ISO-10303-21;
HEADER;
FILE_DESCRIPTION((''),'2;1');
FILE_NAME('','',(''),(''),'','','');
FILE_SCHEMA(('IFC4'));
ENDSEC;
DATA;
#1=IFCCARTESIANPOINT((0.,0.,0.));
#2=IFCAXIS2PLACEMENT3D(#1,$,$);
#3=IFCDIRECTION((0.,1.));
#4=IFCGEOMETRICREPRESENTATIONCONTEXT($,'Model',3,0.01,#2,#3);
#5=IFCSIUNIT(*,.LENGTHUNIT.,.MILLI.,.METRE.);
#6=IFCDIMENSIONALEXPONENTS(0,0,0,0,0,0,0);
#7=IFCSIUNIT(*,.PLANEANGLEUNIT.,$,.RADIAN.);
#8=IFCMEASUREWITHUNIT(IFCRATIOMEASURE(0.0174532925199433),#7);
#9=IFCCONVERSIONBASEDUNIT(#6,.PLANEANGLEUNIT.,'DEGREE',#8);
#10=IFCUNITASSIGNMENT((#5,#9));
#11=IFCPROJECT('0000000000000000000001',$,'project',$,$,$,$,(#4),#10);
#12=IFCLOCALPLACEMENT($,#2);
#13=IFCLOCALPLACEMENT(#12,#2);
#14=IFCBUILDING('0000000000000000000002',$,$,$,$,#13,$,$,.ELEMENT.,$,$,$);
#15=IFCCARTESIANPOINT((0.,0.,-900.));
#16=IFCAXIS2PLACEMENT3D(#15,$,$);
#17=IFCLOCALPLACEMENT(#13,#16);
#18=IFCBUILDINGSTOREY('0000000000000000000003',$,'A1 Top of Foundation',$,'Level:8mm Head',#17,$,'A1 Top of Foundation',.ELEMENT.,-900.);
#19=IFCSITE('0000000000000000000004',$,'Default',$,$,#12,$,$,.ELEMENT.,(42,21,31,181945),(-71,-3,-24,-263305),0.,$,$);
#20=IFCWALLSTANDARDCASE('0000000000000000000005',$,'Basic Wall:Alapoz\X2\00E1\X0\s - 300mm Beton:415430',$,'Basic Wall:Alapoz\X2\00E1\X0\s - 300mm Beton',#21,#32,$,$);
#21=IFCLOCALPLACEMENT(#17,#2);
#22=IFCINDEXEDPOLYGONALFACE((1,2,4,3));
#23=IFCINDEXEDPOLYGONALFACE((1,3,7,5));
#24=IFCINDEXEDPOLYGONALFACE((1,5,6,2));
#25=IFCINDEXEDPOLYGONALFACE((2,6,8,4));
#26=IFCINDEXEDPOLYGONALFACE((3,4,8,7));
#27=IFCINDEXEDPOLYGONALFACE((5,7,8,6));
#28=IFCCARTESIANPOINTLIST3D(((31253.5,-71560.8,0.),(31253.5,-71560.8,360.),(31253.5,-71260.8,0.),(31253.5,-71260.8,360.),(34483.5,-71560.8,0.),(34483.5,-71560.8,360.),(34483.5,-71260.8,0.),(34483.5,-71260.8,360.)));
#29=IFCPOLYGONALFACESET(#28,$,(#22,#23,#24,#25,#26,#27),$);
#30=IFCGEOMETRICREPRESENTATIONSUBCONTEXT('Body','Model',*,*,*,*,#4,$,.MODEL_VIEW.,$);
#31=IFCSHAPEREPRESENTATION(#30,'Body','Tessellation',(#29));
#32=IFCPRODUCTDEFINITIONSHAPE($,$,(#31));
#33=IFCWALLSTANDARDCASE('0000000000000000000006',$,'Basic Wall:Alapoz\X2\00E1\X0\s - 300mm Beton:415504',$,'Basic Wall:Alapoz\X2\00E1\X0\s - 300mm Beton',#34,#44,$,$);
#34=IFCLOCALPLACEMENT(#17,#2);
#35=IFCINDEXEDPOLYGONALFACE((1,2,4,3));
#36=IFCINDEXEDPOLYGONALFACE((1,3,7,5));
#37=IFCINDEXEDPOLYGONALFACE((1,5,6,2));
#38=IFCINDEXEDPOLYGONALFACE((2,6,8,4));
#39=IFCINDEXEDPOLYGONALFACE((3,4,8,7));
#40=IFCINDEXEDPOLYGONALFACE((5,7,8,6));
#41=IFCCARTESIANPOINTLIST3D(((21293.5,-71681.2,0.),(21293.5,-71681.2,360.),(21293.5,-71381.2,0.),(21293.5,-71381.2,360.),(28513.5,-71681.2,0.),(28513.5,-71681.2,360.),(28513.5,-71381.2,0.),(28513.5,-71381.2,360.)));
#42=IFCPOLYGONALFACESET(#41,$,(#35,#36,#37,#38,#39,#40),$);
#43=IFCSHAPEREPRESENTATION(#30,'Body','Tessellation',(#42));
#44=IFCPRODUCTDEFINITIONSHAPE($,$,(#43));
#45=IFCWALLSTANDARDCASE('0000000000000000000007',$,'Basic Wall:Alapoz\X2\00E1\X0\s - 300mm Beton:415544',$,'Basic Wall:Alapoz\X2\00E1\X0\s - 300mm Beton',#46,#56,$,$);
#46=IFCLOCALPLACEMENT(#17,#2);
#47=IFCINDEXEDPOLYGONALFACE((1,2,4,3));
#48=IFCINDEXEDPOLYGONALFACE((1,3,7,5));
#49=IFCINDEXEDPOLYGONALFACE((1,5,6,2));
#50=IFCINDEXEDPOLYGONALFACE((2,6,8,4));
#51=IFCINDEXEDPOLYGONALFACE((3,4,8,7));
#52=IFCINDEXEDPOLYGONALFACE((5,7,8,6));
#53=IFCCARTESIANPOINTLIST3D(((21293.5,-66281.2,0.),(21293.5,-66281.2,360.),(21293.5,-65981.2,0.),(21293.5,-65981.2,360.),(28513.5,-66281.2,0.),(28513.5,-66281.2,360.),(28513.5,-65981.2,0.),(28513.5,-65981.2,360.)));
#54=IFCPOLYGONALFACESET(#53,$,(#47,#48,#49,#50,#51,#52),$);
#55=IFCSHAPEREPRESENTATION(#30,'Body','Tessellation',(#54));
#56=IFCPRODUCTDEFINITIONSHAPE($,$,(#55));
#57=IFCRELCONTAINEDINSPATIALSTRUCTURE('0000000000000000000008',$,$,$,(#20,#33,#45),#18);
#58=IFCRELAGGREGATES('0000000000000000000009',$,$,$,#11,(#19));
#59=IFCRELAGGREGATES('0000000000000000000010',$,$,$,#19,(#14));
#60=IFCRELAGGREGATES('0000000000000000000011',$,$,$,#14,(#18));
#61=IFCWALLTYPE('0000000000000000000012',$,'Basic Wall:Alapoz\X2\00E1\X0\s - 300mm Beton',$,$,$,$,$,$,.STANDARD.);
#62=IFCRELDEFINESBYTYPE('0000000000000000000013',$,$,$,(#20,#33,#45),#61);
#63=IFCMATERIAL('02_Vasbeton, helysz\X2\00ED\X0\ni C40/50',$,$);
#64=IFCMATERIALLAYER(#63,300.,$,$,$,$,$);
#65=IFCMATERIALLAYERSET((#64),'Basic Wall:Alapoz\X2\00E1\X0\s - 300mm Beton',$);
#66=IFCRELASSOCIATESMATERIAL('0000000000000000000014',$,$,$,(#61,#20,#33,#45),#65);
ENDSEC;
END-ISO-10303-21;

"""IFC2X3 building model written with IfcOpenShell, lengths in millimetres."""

from ifc_helpers import new_model, entity, si_unit, converted_unit, direction, frame, frame_2d, origin, place, context, subcontext, project, spatial, polyline, rectangle, extrude, clip, bounded_halfspace, material, layer, layer_set, layer_usage, type_object, element, save


model = new_model("IFC2X3")

# Units and contexts
model_context = context("Model", 3, precision=0.01, world=origin(), true_north=direction((0.0, 1.0)))
body_context = subcontext(model_context, "Body", "Model", "MODEL_VIEW")
ifc_project = project(units=[si_unit("LENGTHUNIT", "METRE", prefix="MILLI"), converted_unit("PLANEANGLEUNIT", "DEGREE", entity("IfcRatioMeasure", 0.0174532925199433), si_unit("PLANEANGLEUNIT", "RADIAN"), dimensions=[0, 0, 0, 0, 0, 0, 0])], contexts=[model_context])

# Site, building, storey
site_placement = place(None, origin())
site = spatial("IfcSite", under=ifc_project, at=site_placement, Name="Default", CompositionType="ELEMENT", RefLatitude=(42, 21, 31, 181945), RefLongitude=(-71, -3, -24, -263305), RefElevation=0.0)
building_placement = place(site_placement, origin())
building = spatial("IfcBuilding", under=site, at=building_placement, CompositionType="ELEMENT")
storey_placement = place(building_placement, frame((0.0, 0.0, -900.0)))
storey = spatial("IfcBuildingStorey", under=building, at=storey_placement, Name="A1 Top of Foundation", ObjectType="Level:8mm Head", LongName="A1 Top of Foundation", CompositionType="ELEMENT", Elevation=-900.0)

# Walls
ifc_material = material(Name="02_Vasbeton, helyszíni C40/50")
ifc_layer = layer(ifc_material, 300.0)
ifc_layer_set = layer_set([ifc_layer], Name="Basic Wall:Alapozás - 300mm Beton")
wall_type = type_object("IfcWallType", Name="Basic Wall:Alapozás - 300mm Beton", PredefinedType="STANDARD", material=ifc_layer_set)
ifc_layer_usage_1 = layer_usage(ifc_layer_set, "AXIS2", "POSITIVE", -150.0)
wall_1_placement = place(storey_placement, frame((31253.5, -71410.8, 0.0)))
element("IfcWallStandardCase", 1, at=wall_1_placement, inside=storey, type_object=wall_type, material=ifc_layer_usage_1, Name="Basic Wall:Alapozás - 300mm Beton:415430", ObjectType="Basic Wall:Alapozás - 300mm Beton", context=body_context, shape_type="Clipping", body=[
    clip(extrude(rectangle(XDim=3230.0, YDim=300.0, at=frame_2d((1615.0, 0.0), x_axis=(-1.0, 0.0))), origin(), (0.0, 0.0, 1.0), 360.0), bounded_halfspace(frame((0.0, -150.0, 360.0), z_axis=(0.0, 0.0, -1.0), x_axis=(0.0, -1.0, 0.0)), True, frame((0.0, -150.0, 360.0), z_axis=(0.0, 0.0, -1.0), x_axis=(0.0, -1.0, 0.0)), polyline([(0.0, 0.0), (-300.0, 0.0), (-300.0, -3230.0), (0.0, -3230.0), (0.0, 0.0)]))),
])
ifc_layer_usage_2 = layer_usage(ifc_layer_set, "AXIS2", "NEGATIVE", 150.0)
wall_2_placement = place(storey_placement, frame((28513.5, -71531.2, 0.0), z_axis=(0.0, 0.0, 1.0), x_axis=(-1.0, 0.0, 0.0)))
element("IfcWallStandardCase", 2, at=wall_2_placement, inside=storey, type_object=wall_type, material=ifc_layer_usage_2, Name="Basic Wall:Alapozás - 300mm Beton:415504", ObjectType="Basic Wall:Alapozás - 300mm Beton", context=body_context, shape_type="Clipping", body=[
    clip(extrude(rectangle(XDim=7220.0, YDim=300.0, at=frame_2d((3610.0, 0.0), x_axis=(-1.0, 0.0))), origin(), (0.0, 0.0, 1.0), 360.0), bounded_halfspace(frame((0.0, -150.0, 360.0), z_axis=(0.0, 0.0, -1.0), x_axis=(-1.0, 0.0, 0.0)), True, frame((0.0, -150.0, 360.0), z_axis=(0.0, 0.0, -1.0), x_axis=(-1.0, 0.0, 0.0)), polyline([(0.0, 0.0), (0.0, 300.0), (-7220.0, 300.0), (-7220.0, 0.0), (0.0, 0.0)]))),
])
ifc_layer_usage_3 = layer_usage(ifc_layer_set, "AXIS2", "POSITIVE", -150.0)
wall_3_placement = place(storey_placement, frame((28513.5, -66131.2, 0.0), z_axis=(0.0, 0.0, 1.0), x_axis=(-1.0, 0.0, 0.0)))
element("IfcWallStandardCase", 3, at=wall_3_placement, inside=storey, type_object=wall_type, material=ifc_layer_usage_3, Name="Basic Wall:Alapozás - 300mm Beton:415544", ObjectType="Basic Wall:Alapozás - 300mm Beton", context=body_context, shape_type="Clipping", body=[
    clip(extrude(rectangle(XDim=7220.0, YDim=300.0, at=frame_2d((3610.0, 0.0), x_axis=(-1.0, 0.0))), origin(), (0.0, 0.0, 1.0), 360.0), bounded_halfspace(frame((0.0, -150.0, 360.0), z_axis=(0.0, 0.0, -1.0), x_axis=(-1.0, 0.0, 0.0)), True, frame((0.0, -150.0, 360.0), z_axis=(0.0, 0.0, -1.0), x_axis=(-1.0, 0.0, 0.0)), polyline([(0.0, 0.0), (0.0, 300.0), (-7220.0, 300.0), (-7220.0, 0.0), (0.0, 0.0)]))),
])

save(model, "model.ifc")
